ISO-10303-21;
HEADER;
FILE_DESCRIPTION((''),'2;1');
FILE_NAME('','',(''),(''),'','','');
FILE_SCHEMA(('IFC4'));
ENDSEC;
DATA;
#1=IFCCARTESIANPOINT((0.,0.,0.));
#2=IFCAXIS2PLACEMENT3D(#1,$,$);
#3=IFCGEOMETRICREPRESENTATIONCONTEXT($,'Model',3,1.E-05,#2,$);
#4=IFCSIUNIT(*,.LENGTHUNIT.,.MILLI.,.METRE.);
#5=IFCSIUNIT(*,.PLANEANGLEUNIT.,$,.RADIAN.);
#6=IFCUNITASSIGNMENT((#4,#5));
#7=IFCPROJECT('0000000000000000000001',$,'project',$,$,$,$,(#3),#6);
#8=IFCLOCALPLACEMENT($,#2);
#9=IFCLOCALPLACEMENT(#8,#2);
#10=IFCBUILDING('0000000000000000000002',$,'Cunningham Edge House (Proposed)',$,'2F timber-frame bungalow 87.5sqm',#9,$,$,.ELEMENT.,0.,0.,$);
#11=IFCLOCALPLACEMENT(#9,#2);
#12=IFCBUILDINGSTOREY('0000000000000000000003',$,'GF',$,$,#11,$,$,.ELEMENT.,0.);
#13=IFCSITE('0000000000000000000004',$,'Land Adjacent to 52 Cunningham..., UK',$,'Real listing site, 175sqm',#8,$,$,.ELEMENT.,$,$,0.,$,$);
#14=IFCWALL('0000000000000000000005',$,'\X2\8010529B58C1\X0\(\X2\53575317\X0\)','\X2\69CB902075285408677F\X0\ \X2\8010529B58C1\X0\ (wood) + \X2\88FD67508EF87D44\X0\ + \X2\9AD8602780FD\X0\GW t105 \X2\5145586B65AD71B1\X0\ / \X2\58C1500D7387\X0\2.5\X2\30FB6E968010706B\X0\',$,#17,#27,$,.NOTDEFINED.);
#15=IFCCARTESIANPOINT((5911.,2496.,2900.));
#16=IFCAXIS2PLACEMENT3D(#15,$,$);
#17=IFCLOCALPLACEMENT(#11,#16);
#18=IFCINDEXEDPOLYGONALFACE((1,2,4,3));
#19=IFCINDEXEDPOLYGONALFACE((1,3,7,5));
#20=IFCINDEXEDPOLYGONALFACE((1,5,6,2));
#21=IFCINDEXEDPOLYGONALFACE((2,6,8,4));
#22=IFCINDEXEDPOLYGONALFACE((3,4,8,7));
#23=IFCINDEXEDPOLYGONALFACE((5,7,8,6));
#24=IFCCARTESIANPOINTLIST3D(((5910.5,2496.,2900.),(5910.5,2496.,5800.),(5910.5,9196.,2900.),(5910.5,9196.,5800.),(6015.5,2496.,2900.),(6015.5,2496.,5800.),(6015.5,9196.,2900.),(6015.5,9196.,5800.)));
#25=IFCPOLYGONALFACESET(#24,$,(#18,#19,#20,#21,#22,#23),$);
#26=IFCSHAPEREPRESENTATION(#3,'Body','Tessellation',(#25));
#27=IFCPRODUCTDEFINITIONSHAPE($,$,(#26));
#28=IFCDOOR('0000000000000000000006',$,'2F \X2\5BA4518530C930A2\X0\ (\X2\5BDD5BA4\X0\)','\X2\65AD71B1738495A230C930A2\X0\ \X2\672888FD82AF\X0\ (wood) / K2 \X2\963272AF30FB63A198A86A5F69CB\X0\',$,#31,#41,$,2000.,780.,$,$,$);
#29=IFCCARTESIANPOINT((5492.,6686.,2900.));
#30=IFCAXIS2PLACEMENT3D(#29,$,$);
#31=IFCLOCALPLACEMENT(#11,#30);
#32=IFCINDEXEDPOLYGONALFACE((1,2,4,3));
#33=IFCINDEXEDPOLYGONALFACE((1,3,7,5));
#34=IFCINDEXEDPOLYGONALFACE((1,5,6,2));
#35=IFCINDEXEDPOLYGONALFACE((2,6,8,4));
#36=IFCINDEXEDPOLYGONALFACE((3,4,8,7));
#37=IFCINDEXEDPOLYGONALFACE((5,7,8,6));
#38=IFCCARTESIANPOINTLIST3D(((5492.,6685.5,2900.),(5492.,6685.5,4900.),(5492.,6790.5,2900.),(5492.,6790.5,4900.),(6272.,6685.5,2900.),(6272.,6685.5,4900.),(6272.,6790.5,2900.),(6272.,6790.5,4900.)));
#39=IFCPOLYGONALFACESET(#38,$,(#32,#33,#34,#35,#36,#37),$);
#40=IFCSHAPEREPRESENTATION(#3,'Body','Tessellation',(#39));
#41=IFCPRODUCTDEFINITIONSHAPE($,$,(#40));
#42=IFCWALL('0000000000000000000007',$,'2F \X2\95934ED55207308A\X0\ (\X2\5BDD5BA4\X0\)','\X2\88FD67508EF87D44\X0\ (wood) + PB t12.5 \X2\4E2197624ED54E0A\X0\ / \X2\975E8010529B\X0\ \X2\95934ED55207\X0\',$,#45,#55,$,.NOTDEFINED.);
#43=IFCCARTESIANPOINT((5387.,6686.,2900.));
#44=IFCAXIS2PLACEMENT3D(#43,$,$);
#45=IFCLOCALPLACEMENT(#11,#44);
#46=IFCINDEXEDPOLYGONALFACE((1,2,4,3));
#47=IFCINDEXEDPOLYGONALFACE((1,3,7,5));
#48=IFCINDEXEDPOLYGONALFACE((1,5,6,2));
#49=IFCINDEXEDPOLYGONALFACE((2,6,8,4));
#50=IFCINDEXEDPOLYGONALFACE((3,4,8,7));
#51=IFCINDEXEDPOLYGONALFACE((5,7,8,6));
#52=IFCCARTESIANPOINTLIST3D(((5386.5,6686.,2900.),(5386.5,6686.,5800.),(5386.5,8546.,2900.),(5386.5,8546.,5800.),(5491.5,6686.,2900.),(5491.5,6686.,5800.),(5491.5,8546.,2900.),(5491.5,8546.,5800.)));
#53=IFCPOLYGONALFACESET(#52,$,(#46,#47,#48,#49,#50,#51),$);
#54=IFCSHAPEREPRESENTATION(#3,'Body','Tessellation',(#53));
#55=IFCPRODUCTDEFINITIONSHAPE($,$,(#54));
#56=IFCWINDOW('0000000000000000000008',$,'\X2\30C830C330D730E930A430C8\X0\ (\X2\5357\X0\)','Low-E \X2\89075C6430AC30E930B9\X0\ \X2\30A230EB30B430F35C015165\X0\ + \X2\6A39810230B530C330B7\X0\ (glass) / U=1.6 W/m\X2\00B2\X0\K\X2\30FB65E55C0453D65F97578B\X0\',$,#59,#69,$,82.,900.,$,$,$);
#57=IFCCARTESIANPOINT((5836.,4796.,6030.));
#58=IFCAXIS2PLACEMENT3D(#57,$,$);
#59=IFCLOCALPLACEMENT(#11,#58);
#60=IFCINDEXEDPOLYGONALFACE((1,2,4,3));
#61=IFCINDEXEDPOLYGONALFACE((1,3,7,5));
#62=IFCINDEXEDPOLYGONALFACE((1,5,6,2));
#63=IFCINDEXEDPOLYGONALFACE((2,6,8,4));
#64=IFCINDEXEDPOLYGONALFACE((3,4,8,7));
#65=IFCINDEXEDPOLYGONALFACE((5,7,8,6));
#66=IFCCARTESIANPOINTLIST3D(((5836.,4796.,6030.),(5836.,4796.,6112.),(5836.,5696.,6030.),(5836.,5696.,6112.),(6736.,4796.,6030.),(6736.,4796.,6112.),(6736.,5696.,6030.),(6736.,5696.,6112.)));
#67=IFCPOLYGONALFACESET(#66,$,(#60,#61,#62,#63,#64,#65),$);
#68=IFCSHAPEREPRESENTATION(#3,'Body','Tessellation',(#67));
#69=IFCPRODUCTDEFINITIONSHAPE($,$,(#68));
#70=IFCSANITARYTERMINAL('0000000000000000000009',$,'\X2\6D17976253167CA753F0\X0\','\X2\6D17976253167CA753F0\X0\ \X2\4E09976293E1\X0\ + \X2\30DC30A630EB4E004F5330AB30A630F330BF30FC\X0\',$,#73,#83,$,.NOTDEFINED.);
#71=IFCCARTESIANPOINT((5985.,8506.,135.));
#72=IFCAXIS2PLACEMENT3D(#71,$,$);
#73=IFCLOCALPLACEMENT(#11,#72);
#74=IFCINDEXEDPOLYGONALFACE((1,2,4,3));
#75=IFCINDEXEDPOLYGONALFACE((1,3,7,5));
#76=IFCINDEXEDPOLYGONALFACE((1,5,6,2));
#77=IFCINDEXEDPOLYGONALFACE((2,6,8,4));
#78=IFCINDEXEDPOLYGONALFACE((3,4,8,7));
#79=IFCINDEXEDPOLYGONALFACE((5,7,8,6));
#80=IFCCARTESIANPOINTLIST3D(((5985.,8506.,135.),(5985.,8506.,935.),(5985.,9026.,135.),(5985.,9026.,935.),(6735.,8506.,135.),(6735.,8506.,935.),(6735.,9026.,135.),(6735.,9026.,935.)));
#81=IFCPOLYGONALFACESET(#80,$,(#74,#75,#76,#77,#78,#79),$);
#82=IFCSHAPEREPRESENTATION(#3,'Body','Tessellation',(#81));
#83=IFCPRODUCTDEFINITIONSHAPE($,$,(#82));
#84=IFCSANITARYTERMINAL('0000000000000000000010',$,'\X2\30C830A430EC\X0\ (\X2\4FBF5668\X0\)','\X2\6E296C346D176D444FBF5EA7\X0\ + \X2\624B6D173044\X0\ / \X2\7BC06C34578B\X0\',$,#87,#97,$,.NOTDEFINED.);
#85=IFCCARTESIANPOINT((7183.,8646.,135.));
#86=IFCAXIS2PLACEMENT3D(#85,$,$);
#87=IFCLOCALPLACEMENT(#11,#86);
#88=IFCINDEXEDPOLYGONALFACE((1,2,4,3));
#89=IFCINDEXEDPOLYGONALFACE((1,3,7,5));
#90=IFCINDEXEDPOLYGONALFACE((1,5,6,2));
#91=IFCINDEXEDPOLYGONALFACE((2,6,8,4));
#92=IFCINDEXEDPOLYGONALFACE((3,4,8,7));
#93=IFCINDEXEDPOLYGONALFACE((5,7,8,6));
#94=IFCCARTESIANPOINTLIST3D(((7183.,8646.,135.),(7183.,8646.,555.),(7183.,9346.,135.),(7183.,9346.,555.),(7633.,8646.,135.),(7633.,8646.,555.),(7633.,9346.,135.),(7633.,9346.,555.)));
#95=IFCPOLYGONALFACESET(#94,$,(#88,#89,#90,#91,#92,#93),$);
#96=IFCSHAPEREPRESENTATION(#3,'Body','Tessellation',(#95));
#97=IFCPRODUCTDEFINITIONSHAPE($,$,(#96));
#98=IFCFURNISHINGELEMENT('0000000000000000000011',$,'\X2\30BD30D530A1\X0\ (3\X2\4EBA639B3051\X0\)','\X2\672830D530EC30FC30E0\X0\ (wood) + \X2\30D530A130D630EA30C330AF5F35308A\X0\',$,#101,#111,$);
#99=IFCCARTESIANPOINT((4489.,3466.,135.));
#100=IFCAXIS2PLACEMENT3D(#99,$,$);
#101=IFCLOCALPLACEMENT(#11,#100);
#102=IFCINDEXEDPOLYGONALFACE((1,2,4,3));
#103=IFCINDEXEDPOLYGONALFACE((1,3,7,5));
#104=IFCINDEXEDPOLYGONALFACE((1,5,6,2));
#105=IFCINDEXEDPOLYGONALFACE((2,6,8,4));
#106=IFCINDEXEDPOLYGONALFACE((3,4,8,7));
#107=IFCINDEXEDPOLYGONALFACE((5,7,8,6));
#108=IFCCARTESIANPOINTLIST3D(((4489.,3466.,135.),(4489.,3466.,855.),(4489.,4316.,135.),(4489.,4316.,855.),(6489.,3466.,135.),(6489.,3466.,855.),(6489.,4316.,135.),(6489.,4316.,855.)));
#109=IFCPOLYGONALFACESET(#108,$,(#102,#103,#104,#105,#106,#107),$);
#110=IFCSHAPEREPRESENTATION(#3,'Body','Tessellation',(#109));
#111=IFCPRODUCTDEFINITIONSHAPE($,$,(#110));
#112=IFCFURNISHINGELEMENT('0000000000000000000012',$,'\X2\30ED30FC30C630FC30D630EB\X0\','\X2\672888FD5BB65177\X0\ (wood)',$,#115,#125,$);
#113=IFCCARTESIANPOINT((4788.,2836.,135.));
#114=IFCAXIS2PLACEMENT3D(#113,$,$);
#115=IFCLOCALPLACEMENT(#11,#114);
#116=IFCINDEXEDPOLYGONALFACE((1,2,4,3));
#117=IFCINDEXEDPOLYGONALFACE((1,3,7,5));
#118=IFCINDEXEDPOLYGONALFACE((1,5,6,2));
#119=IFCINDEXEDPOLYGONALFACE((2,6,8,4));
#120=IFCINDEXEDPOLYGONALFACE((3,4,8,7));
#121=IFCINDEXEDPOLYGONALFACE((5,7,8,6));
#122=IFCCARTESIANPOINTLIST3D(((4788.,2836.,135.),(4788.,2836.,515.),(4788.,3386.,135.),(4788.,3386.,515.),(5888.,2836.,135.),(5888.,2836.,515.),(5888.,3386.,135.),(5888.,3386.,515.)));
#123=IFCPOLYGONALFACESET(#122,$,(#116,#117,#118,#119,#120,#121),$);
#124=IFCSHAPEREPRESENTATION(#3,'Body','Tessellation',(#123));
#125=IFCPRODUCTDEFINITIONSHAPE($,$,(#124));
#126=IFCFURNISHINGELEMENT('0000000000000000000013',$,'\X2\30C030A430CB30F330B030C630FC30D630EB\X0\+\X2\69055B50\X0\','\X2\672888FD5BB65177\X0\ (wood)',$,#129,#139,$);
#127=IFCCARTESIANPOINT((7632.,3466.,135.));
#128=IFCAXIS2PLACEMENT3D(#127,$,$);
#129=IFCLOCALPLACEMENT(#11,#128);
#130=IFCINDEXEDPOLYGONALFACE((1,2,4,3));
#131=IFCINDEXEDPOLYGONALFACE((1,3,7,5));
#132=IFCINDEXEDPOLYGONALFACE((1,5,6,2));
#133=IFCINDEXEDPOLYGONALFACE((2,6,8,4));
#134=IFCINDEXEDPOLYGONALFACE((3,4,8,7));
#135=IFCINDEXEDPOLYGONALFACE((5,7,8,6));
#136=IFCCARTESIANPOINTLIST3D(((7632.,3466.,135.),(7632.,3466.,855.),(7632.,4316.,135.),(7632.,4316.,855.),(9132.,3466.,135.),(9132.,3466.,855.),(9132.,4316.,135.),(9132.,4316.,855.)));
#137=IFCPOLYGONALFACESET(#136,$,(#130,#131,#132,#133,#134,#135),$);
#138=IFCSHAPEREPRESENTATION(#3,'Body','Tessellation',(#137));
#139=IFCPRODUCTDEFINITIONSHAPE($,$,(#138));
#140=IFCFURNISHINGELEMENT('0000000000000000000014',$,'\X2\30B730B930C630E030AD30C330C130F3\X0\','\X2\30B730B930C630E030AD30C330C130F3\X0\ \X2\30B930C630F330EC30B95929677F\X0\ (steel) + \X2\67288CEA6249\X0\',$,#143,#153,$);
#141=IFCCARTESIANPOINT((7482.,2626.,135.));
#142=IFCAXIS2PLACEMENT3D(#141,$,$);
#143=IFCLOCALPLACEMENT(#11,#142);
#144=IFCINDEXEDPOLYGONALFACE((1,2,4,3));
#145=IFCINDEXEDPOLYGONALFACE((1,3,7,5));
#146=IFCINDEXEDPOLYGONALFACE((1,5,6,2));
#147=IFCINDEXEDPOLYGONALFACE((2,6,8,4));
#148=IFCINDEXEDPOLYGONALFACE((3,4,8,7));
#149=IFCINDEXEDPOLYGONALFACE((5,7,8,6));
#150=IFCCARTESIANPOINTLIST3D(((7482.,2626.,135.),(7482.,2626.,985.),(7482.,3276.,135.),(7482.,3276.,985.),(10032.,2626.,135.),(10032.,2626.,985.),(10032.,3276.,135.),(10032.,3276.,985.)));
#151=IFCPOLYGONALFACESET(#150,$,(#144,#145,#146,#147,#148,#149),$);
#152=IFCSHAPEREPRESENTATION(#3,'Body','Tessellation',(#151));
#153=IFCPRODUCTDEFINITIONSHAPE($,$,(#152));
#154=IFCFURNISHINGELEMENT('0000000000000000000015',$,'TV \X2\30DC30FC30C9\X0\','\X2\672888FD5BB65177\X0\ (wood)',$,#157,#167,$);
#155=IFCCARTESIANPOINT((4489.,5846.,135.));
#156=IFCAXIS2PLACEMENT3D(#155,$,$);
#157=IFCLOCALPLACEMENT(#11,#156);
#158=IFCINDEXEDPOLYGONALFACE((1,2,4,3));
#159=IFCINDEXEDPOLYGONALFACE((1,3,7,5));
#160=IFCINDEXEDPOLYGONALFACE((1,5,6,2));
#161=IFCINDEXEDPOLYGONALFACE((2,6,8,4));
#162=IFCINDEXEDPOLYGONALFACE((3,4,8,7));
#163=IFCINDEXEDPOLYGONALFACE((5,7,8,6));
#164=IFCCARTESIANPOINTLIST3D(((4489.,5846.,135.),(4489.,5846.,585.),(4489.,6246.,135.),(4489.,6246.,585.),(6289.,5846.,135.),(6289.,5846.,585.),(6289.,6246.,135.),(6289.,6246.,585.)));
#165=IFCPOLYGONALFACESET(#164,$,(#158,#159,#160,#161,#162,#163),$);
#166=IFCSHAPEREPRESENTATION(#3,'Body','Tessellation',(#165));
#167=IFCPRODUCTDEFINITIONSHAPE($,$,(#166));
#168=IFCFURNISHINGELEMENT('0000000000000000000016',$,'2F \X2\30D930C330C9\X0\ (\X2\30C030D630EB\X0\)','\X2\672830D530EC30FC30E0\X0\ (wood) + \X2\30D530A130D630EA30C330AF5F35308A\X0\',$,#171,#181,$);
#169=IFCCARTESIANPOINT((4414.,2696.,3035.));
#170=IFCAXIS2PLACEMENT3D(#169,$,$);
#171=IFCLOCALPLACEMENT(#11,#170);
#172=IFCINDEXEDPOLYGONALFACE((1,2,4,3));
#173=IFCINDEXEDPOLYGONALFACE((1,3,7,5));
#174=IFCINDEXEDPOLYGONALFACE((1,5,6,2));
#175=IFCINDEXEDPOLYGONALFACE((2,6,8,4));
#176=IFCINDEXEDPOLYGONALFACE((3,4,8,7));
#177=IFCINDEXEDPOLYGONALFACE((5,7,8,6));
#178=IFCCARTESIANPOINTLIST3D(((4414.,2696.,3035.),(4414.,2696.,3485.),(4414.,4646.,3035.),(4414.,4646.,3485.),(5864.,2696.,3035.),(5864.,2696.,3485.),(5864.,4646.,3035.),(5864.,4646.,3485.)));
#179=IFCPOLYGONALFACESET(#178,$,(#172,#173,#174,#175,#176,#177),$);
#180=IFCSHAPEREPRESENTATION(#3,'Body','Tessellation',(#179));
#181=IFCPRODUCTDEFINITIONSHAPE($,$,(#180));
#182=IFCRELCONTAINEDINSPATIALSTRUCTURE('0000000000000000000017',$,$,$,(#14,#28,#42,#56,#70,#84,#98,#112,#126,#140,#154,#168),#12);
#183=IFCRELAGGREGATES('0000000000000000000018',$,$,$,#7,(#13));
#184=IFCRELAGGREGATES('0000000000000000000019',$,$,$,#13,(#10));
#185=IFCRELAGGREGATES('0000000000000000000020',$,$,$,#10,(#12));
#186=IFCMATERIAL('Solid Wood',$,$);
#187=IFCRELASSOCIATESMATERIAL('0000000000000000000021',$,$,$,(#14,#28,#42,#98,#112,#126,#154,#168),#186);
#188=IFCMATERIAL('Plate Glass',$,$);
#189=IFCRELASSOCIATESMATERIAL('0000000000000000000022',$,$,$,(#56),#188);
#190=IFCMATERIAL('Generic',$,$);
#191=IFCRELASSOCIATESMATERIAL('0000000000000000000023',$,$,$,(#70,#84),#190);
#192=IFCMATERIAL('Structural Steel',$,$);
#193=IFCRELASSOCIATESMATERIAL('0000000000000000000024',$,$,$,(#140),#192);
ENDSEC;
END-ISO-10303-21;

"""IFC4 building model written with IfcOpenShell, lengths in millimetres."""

from ifc_helpers import new_model, si_unit, frame, frame_2d, origin, place, context, project, spatial, rectangle, extrude, material, element, fill, save


model = new_model("IFC4")

# Units and contexts
model_context = context("Model", 3, precision=1e-05, world=origin())
ifc_project = project(units=[si_unit("LENGTHUNIT", "METRE", prefix="MILLI"), si_unit("PLANEANGLEUNIT", "RADIAN")], contexts=[model_context])

# Site, building, storey
site_placement = place(None, origin())
site = spatial("IfcSite", under=ifc_project, at=site_placement, Name="Land Adjacent to 52 Cunningham..., UK", ObjectType="Real listing site, 175sqm", CompositionType="ELEMENT", RefElevation=0.0)
building_placement = place(site_placement, origin())
building = spatial("IfcBuilding", under=site, at=building_placement, Name="Cunningham Edge House (Proposed)", ObjectType="2F timber-frame bungalow 87.5sqm", CompositionType="ELEMENT", ElevationOfRefHeight=0.0, ElevationOfTerrain=0.0)
storey_placement = place(building_placement, origin())
storey = spatial("IfcBuildingStorey", under=building, at=storey_placement, Name="GF", CompositionType="ELEMENT", Elevation=0.0)

# Shared definitions
ifc_material_1 = material(Name="Solid Wood")

# Wall, opening, door
wall_1_placement = place(storey_placement, frame((5911.0, 2496.0, 2900.0)))
wall_1 = element("IfcWall", 1, at=wall_1_placement, inside=storey, material=ifc_material_1, Name="耐力壁(南北)", Description="構造用合板 耐力壁 (wood) + 製材軸組 + 高性能GW t105 充填断熱 / 壁倍率2.5・準耐火", PredefinedType="NOTDEFINED", context=model_context, shape_type="SweptSolid", body=[
    extrude(rectangle(XDim=105.0, YDim=6700.0, at=frame_2d((52.0, 3350.0))), frame((5911.0, 2496.0, 2900.0)), (0.0, 0.0, 1.0), 2900.0),
])
opening_1_placement = place(storey_placement, frame((5492.0, 6686.0, 2900.0)))
opening_1 = element("IfcOpeningElement", 2, at=opening_1_placement, cuts=wall_1, PredefinedType="NOTDEFINED", context=model_context, shape_type="SweptSolid", body=[
    extrude(rectangle(XDim=780.0, YDim=105.0, at=frame_2d((390.0, 52.0))), frame((5492.0, 6686.0, 2900.0)), (0.0, 0.0, 1.0), 2000.0),
])
door_1_placement = place(storey_placement, frame((5492.0, 6686.0, 2900.0)))
door_1 = element("IfcDoor", 3, at=door_1_placement, inside=storey, material=ifc_material_1, Name="2F 室内ドア (寝室)", Description="断熱玄関ドア 木製芯 (wood) / K2 防犯・採風機構", OverallHeight=2000.0, OverallWidth=780.0, context=model_context, shape_type="SweptSolid", body=[
    extrude(rectangle(XDim=780.0, YDim=105.0, at=frame_2d((390.0, 52.0))), frame((5492.0, 6686.0, 2900.0)), (0.0, 0.0, 1.0), 2000.0),
])
fill(opening_1, door_1)

# Wall
wall_2_placement = place(storey_placement, frame((5387.0, 6686.0, 2900.0)))
element("IfcWall", 4, at=wall_2_placement, inside=storey, material=ifc_material_1, Name="2F 間仕切り (寝室)", Description="製材軸組 (wood) + PB t12.5 両面仕上 / 非耐力 間仕切", PredefinedType="NOTDEFINED", context=model_context, shape_type="SweptSolid", body=[
    extrude(rectangle(XDim=105.0, YDim=1860.0, at=frame_2d((52.0, 930.0))), frame((5387.0, 6686.0, 2900.0)), (0.0, 0.0, 1.0), 2900.0),
])

# Window
ifc_material_2 = material(Name="Plate Glass")
window_placement = place(storey_placement, frame((5836.0, 4796.0, 6030.0)))
element("IfcWindow", 5, at=window_placement, inside=storey, material=ifc_material_2, Name="トップライト (南)", Description="Low-E 複層ガラス アルゴン封入 + 樹脂サッシ (glass) / U=1.6 W/m²K・日射取得型", OverallHeight=82.0, OverallWidth=900.0, context=model_context, shape_type="SweptSolid", body=[
    extrude(rectangle(XDim=900.0, YDim=900.0, at=frame_2d((450.0, 450.0))), frame((5836.0, 4796.0, 6030.0)), (0.0, 0.0, 1.0), 82.0),
])

# Sanitary terminals
ifc_material_3 = material(Name="Generic")
sanitary_terminal_1_placement = place(storey_placement, frame((5985.0, 8506.0, 135.0)))
element("IfcSanitaryTerminal", 6, at=sanitary_terminal_1_placement, inside=storey, material=ifc_material_3, Name="洗面化粧台", Description="洗面化粧台 三面鏡 + ボウル一体カウンター", PredefinedType="NOTDEFINED", context=model_context, shape_type="SweptSolid", body=[
    extrude(rectangle(XDim=750.0, YDim=520.0, at=frame_2d((375.0, 260.0))), frame((5985.0, 8506.0, 135.0)), (0.0, 0.0, 1.0), 800.0),
])
sanitary_terminal_2_placement = place(storey_placement, frame((7183.0, 8646.0, 135.0)))
element("IfcSanitaryTerminal", 7, at=sanitary_terminal_2_placement, inside=storey, material=ifc_material_3, Name="トイレ (便器)", Description="温水洗浄便座 + 手洗い / 節水型", PredefinedType="NOTDEFINED", context=model_context, shape_type="SweptSolid", body=[
    extrude(rectangle(XDim=450.0, YDim=700.0, at=frame_2d((225.0, 350.0))), frame((7183.0, 8646.0, 135.0)), (0.0, 0.0, 1.0), 420.0),
])

# Furnishing elements
furnishing_1_placement = place(storey_placement, frame((4489.0, 3466.0, 135.0)))
element("IfcFurnishingElement", 8, at=furnishing_1_placement, inside=storey, material=ifc_material_1, Name="ソファ (3人掛け)", Description="木フレーム (wood) + ファブリック張り", context=model_context, shape_type="SweptSolid", body=[
    extrude(rectangle(XDim=2000.0, YDim=850.0, at=frame_2d((1000.0, 425.0))), frame((4489.0, 3466.0, 135.0)), (0.0, 0.0, 1.0), 720.0),
])
furnishing_2_placement = place(storey_placement, frame((4788.0, 2836.0, 135.0)))
element("IfcFurnishingElement", 9, at=furnishing_2_placement, inside=storey, material=ifc_material_1, Name="ローテーブル", Description="木製家具 (wood)", context=model_context, shape_type="SweptSolid", body=[
    extrude(rectangle(XDim=1100.0, YDim=550.0, at=frame_2d((550.0, 275.0))), frame((4788.0, 2836.0, 135.0)), (0.0, 0.0, 1.0), 380.0),
])
furnishing_3_placement = place(storey_placement, frame((7632.0, 3466.0, 135.0)))
element("IfcFurnishingElement", 10, at=furnishing_3_placement, inside=storey, material=ifc_material_1, Name="ダイニングテーブル+椅子", Description="木製家具 (wood)", context=model_context, shape_type="SweptSolid", body=[
    extrude(rectangle(XDim=1500.0, YDim=850.0, at=frame_2d((750.0, 425.0))), frame((7632.0, 3466.0, 135.0)), (0.0, 0.0, 1.0), 720.0),
])
ifc_material_4 = material(Name="Structural Steel")
furnishing_4_placement = place(storey_placement, frame((7482.0, 2626.0, 135.0)))
element("IfcFurnishingElement", 11, at=furnishing_4_placement, inside=storey, material=ifc_material_4, Name="システムキッチン", Description="システムキッチン ステンレス天板 (steel) + 木質扉", context=model_context, shape_type="SweptSolid", body=[
    extrude(rectangle(XDim=2550.0, YDim=650.0, at=frame_2d((1275.0, 325.0))), frame((7482.0, 2626.0, 135.0)), (0.0, 0.0, 1.0), 850.0),
])
furnishing_5_placement = place(storey_placement, frame((4489.0, 5846.0, 135.0)))
element("IfcFurnishingElement", 12, at=furnishing_5_placement, inside=storey, material=ifc_material_1, Name="TV ボード", Description="木製家具 (wood)", context=model_context, shape_type="SweptSolid", body=[
    extrude(rectangle(XDim=1800.0, YDim=400.0, at=frame_2d((900.0, 200.0))), frame((4489.0, 5846.0, 135.0)), (0.0, 0.0, 1.0), 450.0),
])
furnishing_6_placement = place(storey_placement, frame((4414.0, 2696.0, 3035.0)))
element("IfcFurnishingElement", 13, at=furnishing_6_placement, inside=storey, material=ifc_material_1, Name="2F ベッド (ダブル)", Description="木フレーム (wood) + ファブリック張り", context=model_context, shape_type="SweptSolid", body=[
    extrude(rectangle(XDim=1450.0, YDim=1950.0, at=frame_2d((725.0, 975.0))), frame((4414.0, 2696.0, 3035.0)), (0.0, 0.0, 1.0), 450.0),
])

save(model, "model.ifc")
